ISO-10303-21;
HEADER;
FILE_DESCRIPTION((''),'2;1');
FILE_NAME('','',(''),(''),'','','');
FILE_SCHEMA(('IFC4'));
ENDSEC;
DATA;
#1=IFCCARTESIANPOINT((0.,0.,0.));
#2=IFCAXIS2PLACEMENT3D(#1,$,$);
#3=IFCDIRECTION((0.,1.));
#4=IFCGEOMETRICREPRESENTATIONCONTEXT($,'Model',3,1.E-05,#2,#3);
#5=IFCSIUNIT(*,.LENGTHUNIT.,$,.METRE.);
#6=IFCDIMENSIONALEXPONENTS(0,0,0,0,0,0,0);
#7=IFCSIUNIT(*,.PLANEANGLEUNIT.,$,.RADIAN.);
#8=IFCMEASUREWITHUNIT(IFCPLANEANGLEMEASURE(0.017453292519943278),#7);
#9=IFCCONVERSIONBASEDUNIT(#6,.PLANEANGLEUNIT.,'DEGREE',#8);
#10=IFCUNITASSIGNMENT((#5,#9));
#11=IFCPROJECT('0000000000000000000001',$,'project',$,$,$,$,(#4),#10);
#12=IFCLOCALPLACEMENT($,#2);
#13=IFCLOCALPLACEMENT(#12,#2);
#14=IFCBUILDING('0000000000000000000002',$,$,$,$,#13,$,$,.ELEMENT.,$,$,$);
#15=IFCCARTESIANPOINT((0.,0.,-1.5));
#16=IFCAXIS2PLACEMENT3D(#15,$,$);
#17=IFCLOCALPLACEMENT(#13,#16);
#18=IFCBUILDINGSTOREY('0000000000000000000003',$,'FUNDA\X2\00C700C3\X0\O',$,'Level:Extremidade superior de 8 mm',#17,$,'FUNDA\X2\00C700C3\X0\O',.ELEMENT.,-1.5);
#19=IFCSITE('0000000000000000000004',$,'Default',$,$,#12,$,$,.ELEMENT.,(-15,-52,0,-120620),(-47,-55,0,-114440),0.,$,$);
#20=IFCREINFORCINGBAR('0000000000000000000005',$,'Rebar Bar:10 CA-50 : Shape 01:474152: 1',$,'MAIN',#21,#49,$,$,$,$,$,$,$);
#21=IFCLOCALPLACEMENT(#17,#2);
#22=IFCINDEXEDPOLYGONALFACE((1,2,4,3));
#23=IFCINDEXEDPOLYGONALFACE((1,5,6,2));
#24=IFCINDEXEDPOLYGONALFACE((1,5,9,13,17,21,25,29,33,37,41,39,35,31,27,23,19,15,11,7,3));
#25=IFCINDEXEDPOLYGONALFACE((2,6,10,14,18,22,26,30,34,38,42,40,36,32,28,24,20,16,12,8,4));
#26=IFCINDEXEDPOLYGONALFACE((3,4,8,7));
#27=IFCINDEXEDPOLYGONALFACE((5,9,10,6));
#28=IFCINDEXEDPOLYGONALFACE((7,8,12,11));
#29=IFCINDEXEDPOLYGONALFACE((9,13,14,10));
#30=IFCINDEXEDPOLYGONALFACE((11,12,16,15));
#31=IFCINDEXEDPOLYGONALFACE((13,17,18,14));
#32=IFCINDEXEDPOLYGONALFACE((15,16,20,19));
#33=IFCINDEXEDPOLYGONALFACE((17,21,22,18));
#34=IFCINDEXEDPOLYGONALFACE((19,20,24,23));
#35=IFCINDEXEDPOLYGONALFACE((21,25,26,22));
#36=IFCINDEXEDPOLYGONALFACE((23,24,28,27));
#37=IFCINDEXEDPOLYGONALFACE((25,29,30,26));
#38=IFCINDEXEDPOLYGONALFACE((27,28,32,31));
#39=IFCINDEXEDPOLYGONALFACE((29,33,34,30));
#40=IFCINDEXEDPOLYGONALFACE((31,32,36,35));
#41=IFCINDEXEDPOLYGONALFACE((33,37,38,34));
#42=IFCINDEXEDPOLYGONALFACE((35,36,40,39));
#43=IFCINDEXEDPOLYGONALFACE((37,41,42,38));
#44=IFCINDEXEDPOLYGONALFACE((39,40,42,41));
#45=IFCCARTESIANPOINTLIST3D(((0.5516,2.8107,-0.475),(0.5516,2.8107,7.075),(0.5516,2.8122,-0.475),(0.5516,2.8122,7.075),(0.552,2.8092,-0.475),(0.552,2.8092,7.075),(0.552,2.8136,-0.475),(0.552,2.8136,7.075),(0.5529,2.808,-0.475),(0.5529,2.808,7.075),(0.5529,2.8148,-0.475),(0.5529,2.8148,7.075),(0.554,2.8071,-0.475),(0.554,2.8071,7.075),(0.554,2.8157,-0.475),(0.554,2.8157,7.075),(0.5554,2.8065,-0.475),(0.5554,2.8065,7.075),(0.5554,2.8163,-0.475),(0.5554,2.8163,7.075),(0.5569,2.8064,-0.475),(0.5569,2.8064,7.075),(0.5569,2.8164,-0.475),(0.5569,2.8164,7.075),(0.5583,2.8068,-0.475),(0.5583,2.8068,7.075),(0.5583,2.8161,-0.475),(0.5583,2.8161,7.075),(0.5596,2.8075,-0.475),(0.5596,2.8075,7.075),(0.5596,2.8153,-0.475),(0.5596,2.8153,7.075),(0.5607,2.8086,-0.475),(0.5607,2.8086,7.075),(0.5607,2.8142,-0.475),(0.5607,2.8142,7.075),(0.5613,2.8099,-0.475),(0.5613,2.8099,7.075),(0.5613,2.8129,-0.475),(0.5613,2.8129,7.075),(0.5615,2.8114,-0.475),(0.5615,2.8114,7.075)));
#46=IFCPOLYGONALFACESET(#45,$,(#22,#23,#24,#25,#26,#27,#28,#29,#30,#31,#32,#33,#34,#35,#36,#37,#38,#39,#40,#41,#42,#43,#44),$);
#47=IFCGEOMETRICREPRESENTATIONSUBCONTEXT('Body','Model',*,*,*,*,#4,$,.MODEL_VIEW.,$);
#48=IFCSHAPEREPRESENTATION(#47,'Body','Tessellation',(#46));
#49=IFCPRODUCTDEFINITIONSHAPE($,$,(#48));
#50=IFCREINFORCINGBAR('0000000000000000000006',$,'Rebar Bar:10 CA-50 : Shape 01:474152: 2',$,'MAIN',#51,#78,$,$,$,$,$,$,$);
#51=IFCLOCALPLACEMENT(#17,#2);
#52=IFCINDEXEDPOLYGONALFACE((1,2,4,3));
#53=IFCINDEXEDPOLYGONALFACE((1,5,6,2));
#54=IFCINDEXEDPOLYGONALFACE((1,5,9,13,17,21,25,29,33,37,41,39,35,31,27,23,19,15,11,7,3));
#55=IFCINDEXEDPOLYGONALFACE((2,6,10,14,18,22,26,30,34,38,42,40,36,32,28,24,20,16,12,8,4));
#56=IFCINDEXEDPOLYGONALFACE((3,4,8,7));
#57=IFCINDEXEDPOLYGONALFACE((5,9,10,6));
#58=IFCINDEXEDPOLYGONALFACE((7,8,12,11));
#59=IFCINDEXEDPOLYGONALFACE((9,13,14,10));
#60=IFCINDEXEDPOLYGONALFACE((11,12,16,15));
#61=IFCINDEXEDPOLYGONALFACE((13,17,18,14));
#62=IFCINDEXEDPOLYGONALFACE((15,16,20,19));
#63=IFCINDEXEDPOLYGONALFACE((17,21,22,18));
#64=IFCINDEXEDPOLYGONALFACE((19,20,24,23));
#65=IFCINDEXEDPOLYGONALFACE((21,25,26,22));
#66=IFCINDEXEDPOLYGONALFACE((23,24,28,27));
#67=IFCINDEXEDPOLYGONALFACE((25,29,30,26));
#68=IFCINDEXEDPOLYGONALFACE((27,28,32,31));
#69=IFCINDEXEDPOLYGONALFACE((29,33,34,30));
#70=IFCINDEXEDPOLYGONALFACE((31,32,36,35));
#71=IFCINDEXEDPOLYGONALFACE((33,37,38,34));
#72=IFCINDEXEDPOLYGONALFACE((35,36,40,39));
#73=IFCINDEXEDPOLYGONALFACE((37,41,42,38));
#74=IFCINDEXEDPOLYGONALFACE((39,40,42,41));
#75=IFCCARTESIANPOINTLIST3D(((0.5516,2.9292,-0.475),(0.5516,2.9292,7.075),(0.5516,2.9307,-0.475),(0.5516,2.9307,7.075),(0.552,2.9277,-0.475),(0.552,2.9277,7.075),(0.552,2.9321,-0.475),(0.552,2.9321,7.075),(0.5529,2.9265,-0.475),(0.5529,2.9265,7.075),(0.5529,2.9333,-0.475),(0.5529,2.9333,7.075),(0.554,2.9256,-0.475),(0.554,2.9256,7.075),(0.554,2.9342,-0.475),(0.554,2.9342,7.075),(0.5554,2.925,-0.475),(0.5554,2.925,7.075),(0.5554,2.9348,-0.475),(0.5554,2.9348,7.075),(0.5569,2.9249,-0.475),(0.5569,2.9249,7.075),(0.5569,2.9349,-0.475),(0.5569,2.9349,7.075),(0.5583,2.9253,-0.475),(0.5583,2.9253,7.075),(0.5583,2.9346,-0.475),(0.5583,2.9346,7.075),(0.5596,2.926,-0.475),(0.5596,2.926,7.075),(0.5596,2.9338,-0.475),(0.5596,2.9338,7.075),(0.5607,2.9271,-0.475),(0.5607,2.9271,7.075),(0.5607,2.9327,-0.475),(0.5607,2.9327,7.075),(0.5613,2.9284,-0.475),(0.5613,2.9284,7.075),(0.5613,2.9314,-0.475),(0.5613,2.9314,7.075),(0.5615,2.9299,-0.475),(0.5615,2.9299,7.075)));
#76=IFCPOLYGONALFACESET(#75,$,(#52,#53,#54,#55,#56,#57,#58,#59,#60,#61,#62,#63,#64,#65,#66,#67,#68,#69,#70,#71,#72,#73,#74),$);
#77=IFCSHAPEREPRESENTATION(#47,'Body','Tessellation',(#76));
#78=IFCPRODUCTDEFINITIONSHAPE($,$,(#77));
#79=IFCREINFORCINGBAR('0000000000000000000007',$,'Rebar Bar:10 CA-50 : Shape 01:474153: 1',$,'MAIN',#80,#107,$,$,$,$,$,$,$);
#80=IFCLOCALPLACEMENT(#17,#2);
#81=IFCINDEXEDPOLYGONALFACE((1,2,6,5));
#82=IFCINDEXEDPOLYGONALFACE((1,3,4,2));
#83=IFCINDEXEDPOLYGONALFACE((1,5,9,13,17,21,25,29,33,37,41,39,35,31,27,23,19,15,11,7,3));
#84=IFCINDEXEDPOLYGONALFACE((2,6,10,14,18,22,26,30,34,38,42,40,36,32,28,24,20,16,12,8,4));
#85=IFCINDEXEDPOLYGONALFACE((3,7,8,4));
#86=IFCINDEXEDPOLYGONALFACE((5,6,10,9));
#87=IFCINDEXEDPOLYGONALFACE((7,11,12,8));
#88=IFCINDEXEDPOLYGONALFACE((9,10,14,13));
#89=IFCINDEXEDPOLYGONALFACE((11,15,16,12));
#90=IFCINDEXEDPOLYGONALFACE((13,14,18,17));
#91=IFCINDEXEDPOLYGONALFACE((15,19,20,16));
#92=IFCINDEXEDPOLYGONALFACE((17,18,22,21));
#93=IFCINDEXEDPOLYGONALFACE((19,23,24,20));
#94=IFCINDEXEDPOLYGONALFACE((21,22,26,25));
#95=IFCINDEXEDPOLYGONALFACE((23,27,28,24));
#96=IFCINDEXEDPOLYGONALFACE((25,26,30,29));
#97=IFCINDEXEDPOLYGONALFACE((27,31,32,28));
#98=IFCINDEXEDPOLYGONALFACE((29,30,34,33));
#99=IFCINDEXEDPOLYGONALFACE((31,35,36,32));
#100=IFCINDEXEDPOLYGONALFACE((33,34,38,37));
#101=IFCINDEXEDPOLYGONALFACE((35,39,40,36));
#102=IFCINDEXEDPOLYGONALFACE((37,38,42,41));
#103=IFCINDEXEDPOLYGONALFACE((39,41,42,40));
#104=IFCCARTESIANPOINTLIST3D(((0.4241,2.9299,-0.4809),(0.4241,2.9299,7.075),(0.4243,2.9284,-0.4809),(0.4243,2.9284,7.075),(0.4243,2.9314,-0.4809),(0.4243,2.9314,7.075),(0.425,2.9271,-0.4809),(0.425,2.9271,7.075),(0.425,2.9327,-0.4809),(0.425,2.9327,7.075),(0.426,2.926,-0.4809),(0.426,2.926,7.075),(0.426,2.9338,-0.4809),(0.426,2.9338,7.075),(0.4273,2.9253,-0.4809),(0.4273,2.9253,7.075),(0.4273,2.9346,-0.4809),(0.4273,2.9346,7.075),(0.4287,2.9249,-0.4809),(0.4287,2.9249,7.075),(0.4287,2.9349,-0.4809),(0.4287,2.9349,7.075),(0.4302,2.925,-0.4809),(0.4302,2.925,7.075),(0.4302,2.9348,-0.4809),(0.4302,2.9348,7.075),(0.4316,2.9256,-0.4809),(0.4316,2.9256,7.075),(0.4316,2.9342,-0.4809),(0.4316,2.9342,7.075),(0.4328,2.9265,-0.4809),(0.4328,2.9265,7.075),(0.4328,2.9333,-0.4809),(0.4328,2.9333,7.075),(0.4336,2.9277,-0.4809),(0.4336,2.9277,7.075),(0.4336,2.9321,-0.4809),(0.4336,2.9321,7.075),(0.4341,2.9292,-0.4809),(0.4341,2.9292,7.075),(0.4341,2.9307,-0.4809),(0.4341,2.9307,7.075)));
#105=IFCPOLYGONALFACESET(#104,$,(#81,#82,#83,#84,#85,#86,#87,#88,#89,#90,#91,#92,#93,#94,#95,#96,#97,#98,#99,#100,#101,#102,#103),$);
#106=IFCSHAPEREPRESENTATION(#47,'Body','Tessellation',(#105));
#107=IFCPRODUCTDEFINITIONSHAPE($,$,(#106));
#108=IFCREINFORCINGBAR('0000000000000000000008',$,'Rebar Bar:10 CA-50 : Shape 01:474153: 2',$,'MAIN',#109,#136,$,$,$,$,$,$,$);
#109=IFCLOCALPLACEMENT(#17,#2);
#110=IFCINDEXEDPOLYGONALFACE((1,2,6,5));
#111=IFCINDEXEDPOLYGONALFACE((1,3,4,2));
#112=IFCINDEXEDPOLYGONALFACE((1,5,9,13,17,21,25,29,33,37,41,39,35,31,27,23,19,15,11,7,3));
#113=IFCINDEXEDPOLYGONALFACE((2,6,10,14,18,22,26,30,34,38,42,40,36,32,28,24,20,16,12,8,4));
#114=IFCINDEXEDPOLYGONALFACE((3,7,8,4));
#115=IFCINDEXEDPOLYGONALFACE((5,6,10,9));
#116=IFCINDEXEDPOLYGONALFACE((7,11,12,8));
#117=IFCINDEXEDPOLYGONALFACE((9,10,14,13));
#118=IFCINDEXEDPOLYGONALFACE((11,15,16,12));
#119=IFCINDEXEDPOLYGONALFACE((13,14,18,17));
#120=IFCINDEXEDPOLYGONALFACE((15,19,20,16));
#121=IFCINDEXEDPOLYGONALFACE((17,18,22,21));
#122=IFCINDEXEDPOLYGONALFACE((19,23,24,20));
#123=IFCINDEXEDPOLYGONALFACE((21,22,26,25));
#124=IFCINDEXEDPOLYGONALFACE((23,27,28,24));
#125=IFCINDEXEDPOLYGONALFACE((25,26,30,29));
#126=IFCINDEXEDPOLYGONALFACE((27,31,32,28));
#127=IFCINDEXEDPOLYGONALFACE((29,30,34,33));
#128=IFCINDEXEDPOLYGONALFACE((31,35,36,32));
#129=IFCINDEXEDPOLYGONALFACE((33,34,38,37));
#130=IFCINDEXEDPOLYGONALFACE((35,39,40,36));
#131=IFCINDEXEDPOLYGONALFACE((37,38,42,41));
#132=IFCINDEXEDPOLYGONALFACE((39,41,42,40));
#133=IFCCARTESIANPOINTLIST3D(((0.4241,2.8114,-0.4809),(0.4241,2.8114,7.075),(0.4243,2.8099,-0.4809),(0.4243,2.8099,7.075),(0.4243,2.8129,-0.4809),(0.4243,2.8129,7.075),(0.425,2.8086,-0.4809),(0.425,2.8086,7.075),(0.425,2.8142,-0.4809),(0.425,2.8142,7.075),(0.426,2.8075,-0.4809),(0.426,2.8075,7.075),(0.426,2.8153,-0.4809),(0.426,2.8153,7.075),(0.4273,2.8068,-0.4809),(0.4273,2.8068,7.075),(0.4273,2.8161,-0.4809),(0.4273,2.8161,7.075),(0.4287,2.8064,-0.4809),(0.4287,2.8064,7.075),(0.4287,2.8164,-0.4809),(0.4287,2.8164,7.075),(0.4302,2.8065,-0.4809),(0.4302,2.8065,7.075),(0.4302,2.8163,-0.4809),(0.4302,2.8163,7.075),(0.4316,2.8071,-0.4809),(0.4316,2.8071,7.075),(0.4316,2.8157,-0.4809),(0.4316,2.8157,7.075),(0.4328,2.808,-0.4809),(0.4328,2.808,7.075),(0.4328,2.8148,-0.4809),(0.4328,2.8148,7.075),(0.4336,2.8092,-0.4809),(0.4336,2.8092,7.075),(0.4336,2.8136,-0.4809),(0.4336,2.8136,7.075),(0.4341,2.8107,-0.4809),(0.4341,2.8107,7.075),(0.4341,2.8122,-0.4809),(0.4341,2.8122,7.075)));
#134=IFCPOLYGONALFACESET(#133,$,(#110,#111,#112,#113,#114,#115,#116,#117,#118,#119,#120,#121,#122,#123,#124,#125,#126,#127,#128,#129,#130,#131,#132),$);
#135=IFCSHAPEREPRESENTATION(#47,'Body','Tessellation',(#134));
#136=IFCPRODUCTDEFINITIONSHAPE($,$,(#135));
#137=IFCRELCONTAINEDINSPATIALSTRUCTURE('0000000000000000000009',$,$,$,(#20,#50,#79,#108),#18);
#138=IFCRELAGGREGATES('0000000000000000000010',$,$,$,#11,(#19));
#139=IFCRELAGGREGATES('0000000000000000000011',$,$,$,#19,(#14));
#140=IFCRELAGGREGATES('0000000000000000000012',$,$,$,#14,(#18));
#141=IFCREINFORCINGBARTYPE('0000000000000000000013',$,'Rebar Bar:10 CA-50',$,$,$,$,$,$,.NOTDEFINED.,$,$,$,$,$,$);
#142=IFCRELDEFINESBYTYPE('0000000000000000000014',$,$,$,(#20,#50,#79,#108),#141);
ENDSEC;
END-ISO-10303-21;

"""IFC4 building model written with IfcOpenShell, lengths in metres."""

from ifc_helpers import new_model, entity, si_unit, converted_unit, direction, frame, origin, place, context, subcontext, project, spatial, type_object, element, save


model = new_model("IFC4")

# Units and contexts
model_context = context("Model", 3, precision=1e-05, world=origin(), true_north=direction((0.0, 1.0)))
body_context = subcontext(model_context, "Body", "Model", "MODEL_VIEW")
ifc_project = project(units=[si_unit("LENGTHUNIT", "METRE"), converted_unit("PLANEANGLEUNIT", "DEGREE", entity("IfcPlaneAngleMeasure", 0.017453292519943278), si_unit("PLANEANGLEUNIT", "RADIAN"), dimensions=[0, 0, 0, 0, 0, 0, 0])], contexts=[model_context])

# Site, building, storey
site_placement = place(None, origin())
site = spatial("IfcSite", under=ifc_project, at=site_placement, Name="Default", CompositionType="ELEMENT", RefLatitude=(-15, -52, 0, -120620), RefLongitude=(-47, -55, 0, -114440), RefElevation=0.0)
building_placement = place(site_placement, origin())
building = spatial("IfcBuilding", under=site, at=building_placement, CompositionType="ELEMENT")
storey_placement = place(building_placement, frame((0.0, 0.0, -1.5)))
storey = spatial("IfcBuildingStorey", under=building, at=storey_placement, Name="FUNDAÇÃO", ObjectType="Level:Extremidade superior de 8 mm", LongName="FUNDAÇÃO", CompositionType="ELEMENT", Elevation=-1.5)

# Reinforcing bars
reinforcing_bar_type_1 = type_object("IfcReinforcingBarType", Name="Rebar Bar:10 CA-50", PredefinedType="NOTDEFINED")
reinforcing_bar_1_placement = place(storey_placement, origin())
element("IfcReinforcingBar", 1, at=reinforcing_bar_1_placement, inside=storey, type_object=reinforcing_bar_type_1, Name="Rebar Bar:10 CA-50 : Shape 01:474152: 1", ObjectType="MAIN", context=body_context, shape_type="AdvancedSweptSolid", body=[
    entity("IfcSweptDiskSolid", entity("IfcIndexedPolyCurve", entity("IfcCartesianPointList3D", [[0.5565, 2.8114, -0.475], [0.5565, 2.8114, 7.075]]), None, False), 0.005, None, 0.0, 1.0),
])
reinforcing_bar_2_placement = place(storey_placement, origin())
element("IfcReinforcingBar", 2, at=reinforcing_bar_2_placement, inside=storey, type_object=reinforcing_bar_type_1, Name="Rebar Bar:10 CA-50 : Shape 01:474152: 2", ObjectType="MAIN", context=body_context, shape_type="AdvancedSweptSolid", body=[
    entity("IfcSweptDiskSolid", entity("IfcIndexedPolyCurve", entity("IfcCartesianPointList3D", [[0.5565, 2.9299, -0.475], [0.5565, 2.9299, 7.075]]), None, False), 0.005, None, 0.0, 1.0),
])
reinforcing_bar_3_placement = place(storey_placement, origin())
element("IfcReinforcingBar", 3, at=reinforcing_bar_3_placement, inside=storey, type_object=reinforcing_bar_type_1, Name="Rebar Bar:10 CA-50 : Shape 01:474153: 1", ObjectType="MAIN", context=body_context, shape_type="AdvancedSweptSolid", body=[
    entity("IfcSweptDiskSolid", entity("IfcIndexedPolyCurve", entity("IfcCartesianPointList3D", [[0.4291, 2.9299, 7.075], [0.4291, 2.9299, -0.4809]]), None, False), 0.005, None, 0.0, 1.0),
])
reinforcing_bar_4_placement = place(storey_placement, origin())
element("IfcReinforcingBar", 4, at=reinforcing_bar_4_placement, inside=storey, type_object=reinforcing_bar_type_1, Name="Rebar Bar:10 CA-50 : Shape 01:474153: 2", ObjectType="MAIN", context=body_context, shape_type="AdvancedSweptSolid", body=[
    entity("IfcSweptDiskSolid", entity("IfcIndexedPolyCurve", entity("IfcCartesianPointList3D", [[0.4291, 2.8114, 7.075], [0.4291, 2.8114, -0.4809]]), None, False), 0.005, None, 0.0, 1.0),
])

save(model, "model.ifc")
